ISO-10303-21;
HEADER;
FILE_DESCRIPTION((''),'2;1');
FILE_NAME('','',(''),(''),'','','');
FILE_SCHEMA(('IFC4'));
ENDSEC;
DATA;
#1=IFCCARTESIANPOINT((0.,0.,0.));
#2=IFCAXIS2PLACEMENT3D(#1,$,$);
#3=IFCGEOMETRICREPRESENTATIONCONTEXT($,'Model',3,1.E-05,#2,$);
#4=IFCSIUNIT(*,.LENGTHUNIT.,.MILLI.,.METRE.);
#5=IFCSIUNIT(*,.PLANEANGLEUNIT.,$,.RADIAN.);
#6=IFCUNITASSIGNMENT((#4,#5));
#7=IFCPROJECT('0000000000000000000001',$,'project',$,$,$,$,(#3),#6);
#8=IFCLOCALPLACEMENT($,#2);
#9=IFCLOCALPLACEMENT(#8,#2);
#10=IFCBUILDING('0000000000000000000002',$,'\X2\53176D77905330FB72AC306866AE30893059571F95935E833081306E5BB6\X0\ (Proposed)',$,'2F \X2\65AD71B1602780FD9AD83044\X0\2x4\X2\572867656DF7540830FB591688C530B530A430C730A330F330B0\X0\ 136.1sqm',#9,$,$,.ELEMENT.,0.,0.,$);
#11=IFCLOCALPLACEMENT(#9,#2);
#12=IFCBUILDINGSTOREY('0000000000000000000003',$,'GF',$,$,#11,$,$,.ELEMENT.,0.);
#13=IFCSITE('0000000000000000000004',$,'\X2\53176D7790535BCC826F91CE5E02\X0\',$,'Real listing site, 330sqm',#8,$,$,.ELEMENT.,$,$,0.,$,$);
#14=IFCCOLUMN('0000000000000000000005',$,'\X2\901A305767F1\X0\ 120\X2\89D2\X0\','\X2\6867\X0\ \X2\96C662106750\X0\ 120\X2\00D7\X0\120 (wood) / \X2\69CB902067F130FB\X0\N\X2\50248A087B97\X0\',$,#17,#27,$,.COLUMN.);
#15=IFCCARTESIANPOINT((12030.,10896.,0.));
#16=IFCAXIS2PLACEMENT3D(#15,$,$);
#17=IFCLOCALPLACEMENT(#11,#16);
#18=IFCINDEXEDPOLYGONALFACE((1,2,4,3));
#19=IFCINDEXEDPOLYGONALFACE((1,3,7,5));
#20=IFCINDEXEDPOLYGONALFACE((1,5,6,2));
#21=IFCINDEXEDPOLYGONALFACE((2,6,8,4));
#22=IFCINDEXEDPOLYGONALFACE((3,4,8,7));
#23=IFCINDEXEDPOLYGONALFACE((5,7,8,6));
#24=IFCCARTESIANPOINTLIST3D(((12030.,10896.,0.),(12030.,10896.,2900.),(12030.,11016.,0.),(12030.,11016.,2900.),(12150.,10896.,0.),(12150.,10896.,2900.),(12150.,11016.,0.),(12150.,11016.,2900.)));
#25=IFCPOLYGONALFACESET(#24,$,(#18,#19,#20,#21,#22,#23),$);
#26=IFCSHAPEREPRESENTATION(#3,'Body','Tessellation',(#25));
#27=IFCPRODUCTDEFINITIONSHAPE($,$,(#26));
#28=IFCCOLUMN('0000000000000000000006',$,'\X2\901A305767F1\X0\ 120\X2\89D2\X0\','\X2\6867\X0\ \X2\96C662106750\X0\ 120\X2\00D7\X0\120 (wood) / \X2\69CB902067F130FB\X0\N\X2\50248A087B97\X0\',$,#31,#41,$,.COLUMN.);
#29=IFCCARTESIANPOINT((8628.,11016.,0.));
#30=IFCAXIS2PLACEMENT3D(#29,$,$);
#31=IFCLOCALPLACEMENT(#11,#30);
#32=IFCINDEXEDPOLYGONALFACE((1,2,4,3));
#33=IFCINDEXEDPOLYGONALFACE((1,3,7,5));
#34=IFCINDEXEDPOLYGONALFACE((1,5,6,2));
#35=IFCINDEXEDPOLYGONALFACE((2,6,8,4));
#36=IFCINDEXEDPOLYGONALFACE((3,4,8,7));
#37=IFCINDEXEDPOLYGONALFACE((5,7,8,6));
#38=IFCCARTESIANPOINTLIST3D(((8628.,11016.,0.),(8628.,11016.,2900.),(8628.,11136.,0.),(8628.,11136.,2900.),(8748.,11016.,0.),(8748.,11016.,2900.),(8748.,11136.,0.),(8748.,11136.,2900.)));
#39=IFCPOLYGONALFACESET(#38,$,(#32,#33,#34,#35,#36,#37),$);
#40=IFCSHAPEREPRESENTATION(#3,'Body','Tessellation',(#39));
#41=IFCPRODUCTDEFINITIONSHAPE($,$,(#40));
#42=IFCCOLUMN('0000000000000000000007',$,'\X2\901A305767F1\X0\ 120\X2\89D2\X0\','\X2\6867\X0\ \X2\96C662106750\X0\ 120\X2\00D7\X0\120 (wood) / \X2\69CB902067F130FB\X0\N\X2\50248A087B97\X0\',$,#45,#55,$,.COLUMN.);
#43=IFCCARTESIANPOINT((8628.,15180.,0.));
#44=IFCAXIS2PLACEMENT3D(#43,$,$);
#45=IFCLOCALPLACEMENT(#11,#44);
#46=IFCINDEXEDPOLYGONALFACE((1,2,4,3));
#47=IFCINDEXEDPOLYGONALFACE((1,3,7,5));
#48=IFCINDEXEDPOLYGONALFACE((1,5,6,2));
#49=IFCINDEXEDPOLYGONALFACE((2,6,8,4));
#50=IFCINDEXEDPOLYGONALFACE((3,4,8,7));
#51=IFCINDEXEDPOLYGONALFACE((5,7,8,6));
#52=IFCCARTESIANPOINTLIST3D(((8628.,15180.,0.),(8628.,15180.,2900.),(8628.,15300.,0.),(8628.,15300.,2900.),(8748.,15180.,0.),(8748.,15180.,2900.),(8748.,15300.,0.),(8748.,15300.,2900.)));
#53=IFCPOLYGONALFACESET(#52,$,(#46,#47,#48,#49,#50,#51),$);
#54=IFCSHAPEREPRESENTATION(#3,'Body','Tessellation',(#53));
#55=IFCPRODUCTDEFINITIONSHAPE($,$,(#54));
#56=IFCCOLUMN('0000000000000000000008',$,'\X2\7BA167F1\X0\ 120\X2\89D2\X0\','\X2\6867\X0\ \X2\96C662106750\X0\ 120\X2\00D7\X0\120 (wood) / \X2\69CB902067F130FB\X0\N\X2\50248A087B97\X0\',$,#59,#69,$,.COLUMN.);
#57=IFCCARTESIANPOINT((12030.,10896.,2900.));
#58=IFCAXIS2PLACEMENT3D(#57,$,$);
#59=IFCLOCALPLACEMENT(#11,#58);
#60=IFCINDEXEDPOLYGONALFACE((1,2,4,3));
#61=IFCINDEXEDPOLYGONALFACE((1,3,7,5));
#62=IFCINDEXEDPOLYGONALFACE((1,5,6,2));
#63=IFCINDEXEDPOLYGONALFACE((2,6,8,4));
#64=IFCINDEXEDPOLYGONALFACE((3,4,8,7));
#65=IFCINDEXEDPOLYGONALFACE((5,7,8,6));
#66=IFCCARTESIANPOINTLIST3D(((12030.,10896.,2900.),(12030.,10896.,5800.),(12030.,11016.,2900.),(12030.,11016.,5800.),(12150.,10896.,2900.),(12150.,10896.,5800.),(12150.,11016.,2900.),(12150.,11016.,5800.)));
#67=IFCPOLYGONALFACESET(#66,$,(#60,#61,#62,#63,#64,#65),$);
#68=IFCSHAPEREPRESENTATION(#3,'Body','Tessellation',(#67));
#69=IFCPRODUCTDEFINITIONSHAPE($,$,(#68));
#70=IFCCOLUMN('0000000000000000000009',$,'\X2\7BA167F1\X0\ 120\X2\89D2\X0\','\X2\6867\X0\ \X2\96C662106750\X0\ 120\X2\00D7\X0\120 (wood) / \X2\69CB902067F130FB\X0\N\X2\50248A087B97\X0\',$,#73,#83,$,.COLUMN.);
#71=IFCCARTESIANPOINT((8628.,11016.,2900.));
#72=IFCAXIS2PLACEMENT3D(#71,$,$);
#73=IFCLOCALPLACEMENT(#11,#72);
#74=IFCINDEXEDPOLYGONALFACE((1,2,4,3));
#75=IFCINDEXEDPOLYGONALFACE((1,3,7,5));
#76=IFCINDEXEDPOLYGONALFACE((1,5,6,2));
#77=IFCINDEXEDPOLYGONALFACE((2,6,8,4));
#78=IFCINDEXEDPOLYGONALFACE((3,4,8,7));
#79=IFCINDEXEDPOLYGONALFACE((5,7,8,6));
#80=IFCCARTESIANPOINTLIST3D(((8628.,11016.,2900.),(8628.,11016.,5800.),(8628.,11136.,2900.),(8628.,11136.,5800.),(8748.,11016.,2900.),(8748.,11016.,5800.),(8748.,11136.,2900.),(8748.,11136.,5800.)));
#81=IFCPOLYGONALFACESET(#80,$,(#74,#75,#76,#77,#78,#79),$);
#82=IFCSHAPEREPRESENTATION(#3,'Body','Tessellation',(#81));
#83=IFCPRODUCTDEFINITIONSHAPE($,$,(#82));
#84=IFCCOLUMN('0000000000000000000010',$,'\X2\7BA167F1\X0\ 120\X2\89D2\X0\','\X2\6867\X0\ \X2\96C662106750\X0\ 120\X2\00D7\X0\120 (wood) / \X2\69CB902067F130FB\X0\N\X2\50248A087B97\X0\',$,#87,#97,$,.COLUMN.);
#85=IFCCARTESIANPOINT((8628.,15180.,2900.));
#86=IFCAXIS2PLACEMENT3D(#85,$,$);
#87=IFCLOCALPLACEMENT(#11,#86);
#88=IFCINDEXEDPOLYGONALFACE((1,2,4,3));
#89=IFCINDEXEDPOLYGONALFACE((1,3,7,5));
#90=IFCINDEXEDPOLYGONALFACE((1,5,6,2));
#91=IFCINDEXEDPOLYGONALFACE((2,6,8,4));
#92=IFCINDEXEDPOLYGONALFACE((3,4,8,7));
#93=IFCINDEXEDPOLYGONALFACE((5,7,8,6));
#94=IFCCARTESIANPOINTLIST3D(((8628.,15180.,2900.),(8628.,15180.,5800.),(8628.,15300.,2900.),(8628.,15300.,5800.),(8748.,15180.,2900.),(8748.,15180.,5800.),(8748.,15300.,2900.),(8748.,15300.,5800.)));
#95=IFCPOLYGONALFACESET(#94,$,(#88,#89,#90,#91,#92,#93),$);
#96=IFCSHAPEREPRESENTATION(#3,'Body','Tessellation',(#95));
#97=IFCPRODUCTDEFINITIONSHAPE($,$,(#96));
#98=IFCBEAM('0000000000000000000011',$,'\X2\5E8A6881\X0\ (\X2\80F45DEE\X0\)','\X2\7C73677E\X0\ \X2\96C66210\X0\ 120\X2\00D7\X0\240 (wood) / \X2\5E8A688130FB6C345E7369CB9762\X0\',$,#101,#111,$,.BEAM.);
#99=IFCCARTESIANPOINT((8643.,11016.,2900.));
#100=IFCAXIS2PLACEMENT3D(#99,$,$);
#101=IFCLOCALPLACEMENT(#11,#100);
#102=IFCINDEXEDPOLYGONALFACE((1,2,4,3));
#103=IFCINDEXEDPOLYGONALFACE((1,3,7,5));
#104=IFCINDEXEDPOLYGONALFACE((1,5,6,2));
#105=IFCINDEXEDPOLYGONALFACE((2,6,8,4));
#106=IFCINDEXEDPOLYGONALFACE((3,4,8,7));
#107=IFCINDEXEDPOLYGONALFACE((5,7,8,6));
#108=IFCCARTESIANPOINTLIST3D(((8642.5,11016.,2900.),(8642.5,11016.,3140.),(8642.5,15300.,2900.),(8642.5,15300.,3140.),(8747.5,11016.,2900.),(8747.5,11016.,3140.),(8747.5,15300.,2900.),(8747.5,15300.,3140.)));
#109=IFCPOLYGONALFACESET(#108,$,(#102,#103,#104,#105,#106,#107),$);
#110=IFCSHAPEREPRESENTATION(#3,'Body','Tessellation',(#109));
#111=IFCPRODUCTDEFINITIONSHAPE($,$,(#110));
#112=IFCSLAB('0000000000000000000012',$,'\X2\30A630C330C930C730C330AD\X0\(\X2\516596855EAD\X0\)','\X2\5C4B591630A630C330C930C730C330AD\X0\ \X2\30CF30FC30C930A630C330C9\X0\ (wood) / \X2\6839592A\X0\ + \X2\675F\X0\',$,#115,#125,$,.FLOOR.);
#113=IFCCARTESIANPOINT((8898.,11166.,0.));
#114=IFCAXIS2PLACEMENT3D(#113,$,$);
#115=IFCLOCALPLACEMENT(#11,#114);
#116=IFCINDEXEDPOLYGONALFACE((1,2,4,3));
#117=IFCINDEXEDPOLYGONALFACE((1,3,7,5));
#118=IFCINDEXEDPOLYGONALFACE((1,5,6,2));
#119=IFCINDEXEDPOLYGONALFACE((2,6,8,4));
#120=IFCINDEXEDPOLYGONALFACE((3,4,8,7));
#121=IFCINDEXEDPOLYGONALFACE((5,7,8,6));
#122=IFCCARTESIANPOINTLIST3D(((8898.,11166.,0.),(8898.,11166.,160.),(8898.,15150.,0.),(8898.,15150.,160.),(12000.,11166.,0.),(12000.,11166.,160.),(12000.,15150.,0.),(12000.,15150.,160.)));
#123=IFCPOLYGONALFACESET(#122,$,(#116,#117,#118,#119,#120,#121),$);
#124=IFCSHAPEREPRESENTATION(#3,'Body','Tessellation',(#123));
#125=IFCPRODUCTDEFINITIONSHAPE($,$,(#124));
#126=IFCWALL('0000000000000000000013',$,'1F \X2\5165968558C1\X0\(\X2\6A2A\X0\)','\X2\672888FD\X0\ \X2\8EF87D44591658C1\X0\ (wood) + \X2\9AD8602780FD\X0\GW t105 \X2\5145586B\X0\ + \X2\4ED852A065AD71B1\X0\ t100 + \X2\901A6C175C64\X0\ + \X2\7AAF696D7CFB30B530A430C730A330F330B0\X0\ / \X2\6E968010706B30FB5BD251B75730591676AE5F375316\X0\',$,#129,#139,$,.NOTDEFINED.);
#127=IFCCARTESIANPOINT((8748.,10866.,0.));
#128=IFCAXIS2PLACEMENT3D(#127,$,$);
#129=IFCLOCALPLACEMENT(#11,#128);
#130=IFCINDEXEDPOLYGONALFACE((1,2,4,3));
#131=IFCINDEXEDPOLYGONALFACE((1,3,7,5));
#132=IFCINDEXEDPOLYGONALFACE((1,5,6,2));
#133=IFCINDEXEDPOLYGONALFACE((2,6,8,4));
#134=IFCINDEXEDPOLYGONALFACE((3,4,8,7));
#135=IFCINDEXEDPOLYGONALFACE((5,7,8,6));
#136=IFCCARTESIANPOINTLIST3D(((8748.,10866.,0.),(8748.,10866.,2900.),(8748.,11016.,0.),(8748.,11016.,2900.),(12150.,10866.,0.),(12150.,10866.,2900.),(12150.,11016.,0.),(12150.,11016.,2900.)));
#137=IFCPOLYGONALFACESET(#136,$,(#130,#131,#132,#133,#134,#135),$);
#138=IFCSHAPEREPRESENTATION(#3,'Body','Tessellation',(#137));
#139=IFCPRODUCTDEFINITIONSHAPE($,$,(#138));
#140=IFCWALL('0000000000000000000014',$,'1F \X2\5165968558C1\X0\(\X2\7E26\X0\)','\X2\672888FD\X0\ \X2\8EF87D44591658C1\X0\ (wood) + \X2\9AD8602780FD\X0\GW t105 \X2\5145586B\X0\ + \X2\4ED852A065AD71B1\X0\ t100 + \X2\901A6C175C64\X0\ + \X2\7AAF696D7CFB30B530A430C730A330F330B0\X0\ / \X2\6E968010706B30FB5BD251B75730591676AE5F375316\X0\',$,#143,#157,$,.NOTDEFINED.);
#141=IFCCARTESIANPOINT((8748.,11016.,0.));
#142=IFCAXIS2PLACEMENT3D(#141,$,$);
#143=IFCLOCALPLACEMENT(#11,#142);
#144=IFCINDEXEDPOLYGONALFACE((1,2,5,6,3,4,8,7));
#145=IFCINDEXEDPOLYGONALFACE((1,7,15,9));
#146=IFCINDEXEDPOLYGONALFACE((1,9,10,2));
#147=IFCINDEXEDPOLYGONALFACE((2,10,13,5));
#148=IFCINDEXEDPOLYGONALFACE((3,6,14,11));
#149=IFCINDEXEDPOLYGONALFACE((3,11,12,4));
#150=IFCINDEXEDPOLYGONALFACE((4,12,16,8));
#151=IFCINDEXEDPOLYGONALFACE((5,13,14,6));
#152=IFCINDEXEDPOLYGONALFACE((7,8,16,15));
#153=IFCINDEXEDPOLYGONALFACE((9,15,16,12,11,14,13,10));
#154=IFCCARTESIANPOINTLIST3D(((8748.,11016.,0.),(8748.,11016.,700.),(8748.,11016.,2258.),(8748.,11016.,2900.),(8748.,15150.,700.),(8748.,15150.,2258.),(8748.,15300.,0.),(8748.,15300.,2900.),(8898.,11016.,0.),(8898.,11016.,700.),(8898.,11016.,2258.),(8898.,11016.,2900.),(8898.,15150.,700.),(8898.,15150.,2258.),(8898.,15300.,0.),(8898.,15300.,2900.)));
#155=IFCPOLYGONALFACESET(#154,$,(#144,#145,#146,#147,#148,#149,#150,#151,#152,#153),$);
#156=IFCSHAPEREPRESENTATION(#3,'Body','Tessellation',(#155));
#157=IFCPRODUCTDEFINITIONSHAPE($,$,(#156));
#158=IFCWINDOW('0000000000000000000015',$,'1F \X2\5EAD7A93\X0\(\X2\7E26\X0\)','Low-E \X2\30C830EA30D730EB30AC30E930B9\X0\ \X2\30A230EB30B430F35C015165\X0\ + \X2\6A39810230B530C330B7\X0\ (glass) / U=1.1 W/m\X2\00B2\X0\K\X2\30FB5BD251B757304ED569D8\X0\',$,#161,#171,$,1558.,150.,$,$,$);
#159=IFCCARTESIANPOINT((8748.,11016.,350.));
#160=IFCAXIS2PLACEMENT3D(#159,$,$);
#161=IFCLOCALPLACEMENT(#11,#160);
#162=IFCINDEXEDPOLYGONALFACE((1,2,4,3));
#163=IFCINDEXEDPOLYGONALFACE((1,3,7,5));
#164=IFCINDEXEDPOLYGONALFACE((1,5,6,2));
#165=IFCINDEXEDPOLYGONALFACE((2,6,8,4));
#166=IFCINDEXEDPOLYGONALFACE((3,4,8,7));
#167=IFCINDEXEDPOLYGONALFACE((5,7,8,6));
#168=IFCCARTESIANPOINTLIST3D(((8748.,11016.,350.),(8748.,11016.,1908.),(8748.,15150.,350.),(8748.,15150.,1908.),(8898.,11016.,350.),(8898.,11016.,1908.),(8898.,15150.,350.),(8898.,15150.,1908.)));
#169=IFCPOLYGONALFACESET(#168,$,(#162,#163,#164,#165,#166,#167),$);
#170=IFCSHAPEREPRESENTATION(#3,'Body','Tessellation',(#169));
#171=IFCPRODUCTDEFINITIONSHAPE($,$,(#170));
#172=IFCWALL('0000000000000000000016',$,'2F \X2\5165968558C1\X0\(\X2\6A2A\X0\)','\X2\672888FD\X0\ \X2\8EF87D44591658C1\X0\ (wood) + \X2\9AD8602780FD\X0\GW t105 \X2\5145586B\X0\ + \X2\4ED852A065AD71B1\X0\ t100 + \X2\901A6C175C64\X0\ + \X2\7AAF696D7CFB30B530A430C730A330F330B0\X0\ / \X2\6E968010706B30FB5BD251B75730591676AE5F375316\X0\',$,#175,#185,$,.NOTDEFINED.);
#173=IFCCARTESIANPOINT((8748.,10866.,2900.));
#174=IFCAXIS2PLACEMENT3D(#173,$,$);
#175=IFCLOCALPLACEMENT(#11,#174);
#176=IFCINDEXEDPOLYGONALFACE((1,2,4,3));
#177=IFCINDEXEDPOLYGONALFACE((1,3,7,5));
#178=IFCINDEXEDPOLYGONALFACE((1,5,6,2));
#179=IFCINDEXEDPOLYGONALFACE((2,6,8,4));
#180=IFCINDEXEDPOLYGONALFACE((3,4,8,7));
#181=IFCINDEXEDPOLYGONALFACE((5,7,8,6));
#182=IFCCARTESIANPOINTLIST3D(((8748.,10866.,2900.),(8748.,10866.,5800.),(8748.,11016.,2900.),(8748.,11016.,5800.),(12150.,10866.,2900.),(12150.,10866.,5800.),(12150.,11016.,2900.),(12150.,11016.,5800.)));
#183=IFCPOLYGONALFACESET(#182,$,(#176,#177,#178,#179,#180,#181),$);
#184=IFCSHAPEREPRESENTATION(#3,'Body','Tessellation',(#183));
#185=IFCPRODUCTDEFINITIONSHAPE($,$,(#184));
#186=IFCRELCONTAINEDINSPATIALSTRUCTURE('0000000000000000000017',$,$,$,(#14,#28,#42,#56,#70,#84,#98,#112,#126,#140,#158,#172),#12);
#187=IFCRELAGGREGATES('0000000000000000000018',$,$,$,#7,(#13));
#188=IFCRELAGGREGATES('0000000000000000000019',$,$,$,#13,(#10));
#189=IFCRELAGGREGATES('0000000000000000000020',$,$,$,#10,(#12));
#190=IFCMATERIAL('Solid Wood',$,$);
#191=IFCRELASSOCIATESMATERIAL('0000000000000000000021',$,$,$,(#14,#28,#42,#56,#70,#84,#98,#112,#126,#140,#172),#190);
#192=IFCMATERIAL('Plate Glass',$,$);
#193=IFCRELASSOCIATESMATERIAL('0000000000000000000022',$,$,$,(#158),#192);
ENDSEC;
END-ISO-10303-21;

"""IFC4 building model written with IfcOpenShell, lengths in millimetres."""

from ifc_helpers import new_model, si_unit, frame, frame_2d, origin, place, context, project, spatial, rectangle, extrude, material, element, fill, save


model = new_model("IFC4")

# Units and contexts
model_context = context("Model", 3, precision=1e-05, world=origin())
ifc_project = project(units=[si_unit("LENGTHUNIT", "METRE", prefix="MILLI"), si_unit("PLANEANGLEUNIT", "RADIAN")], contexts=[model_context])

# Site, building, storey
site_placement = place(None, origin())
site = spatial("IfcSite", under=ifc_project, at=site_placement, Name="北海道富良野市", ObjectType="Real listing site, 330sqm", CompositionType="ELEMENT", RefElevation=0.0)
building_placement = place(site_placement, origin())
building = spatial("IfcBuilding", under=site, at=building_placement, Name="北海道・犬と暮らす土間広めの家 (Proposed)", ObjectType="2F 断熱性能高い2x4在来混合・外装サイディング 136.1sqm", CompositionType="ELEMENT", ElevationOfRefHeight=0.0, ElevationOfTerrain=0.0)
storey_placement = place(building_placement, origin())
storey = spatial("IfcBuildingStorey", under=building, at=storey_placement, Name="GF", CompositionType="ELEMENT", Elevation=0.0)

# Columns
ifc_material_1 = material(Name="Solid Wood")
column_1_placement = place(storey_placement, frame((12030.0, 10896.0, 0.0)))
element("IfcColumn", 1, at=column_1_placement, inside=storey, material=ifc_material_1, Name="通し柱 120角", Description="桧 集成材 120×120 (wood) / 構造柱・N値計算", PredefinedType="COLUMN", context=model_context, shape_type="SweptSolid", body=[
    extrude(rectangle(XDim=120.0, YDim=120.0, at=frame_2d((60.0, 60.0))), frame((12030.0, 10896.0, 0.0)), (0.0, 0.0, 1.0), 2900.0),
])
column_2_placement = place(storey_placement, frame((8628.0, 11016.0, 0.0)))
element("IfcColumn", 2, at=column_2_placement, inside=storey, material=ifc_material_1, Name="通し柱 120角", Description="桧 集成材 120×120 (wood) / 構造柱・N値計算", PredefinedType="COLUMN", context=model_context, shape_type="SweptSolid", body=[
    extrude(rectangle(XDim=120.0, YDim=120.0, at=frame_2d((60.0, 60.0))), frame((8628.0, 11016.0, 0.0)), (0.0, 0.0, 1.0), 2900.0),
])
column_3_placement = place(storey_placement, frame((8628.0, 15180.0, 0.0)))
element("IfcColumn", 3, at=column_3_placement, inside=storey, material=ifc_material_1, Name="通し柱 120角", Description="桧 集成材 120×120 (wood) / 構造柱・N値計算", PredefinedType="COLUMN", context=model_context, shape_type="SweptSolid", body=[
    extrude(rectangle(XDim=120.0, YDim=120.0, at=frame_2d((60.0, 60.0))), frame((8628.0, 15180.0, 0.0)), (0.0, 0.0, 1.0), 2900.0),
])
column_4_placement = place(storey_placement, frame((12030.0, 10896.0, 2900.0)))
element("IfcColumn", 4, at=column_4_placement, inside=storey, material=ifc_material_1, Name="管柱 120角", Description="桧 集成材 120×120 (wood) / 構造柱・N値計算", PredefinedType="COLUMN", context=model_context, shape_type="SweptSolid", body=[
    extrude(rectangle(XDim=120.0, YDim=120.0, at=frame_2d((60.0, 60.0))), frame((12030.0, 10896.0, 2900.0)), (0.0, 0.0, 1.0), 2900.0),
])
column_5_placement = place(storey_placement, frame((8628.0, 11016.0, 2900.0)))
element("IfcColumn", 5, at=column_5_placement, inside=storey, material=ifc_material_1, Name="管柱 120角", Description="桧 集成材 120×120 (wood) / 構造柱・N値計算", PredefinedType="COLUMN", context=model_context, shape_type="SweptSolid", body=[
    extrude(rectangle(XDim=120.0, YDim=120.0, at=frame_2d((60.0, 60.0))), frame((8628.0, 11016.0, 2900.0)), (0.0, 0.0, 1.0), 2900.0),
])
column_6_placement = place(storey_placement, frame((8628.0, 15180.0, 2900.0)))
element("IfcColumn", 6, at=column_6_placement, inside=storey, material=ifc_material_1, Name="管柱 120角", Description="桧 集成材 120×120 (wood) / 構造柱・N値計算", PredefinedType="COLUMN", context=model_context, shape_type="SweptSolid", body=[
    extrude(rectangle(XDim=120.0, YDim=120.0, at=frame_2d((60.0, 60.0))), frame((8628.0, 15180.0, 2900.0)), (0.0, 0.0, 1.0), 2900.0),
])

# Beam
beam_1_placement = place(storey_placement, frame((8643.0, 11016.0, 2900.0)))
element("IfcBeam", 7, at=beam_1_placement, inside=storey, material=ifc_material_1, Name="床梁 (胴差)", Description="米松 集成 120×240 (wood) / 床梁・水平構面", PredefinedType="BEAM", context=model_context, shape_type="SweptSolid", body=[
    extrude(rectangle(XDim=105.0, YDim=4284.0, at=frame_2d((52.0, 2142.0))), frame((8643.0, 11016.0, 2900.0)), (0.0, 0.0, 1.0), 240.0),
])

# Slab
slab_placement = place(storey_placement, frame((8898.0, 11166.0, 0.0)))
element("IfcSlab", 8, at=slab_placement, inside=storey, material=ifc_material_1, Name="ウッドデッキ(入隅庭)", Description="屋外ウッドデッキ ハードウッド (wood) / 根太 + 束", PredefinedType="FLOOR", context=model_context, shape_type="SweptSolid", body=[
    extrude(rectangle(XDim=3102.0, YDim=3984.0, at=frame_2d((1551.0, 1992.0))), frame((8898.0, 11166.0, 0.0)), (0.0, 0.0, 1.0), 160.0),
])

# Wall
wall_1_placement = place(storey_placement, frame((8748.0, 10866.0, 0.0)))
element("IfcWall", 9, at=wall_1_placement, inside=storey, material=ifc_material_1, Name="1F 入隅壁(横)", Description="木製 軸組外壁 (wood) + 高性能GW t105 充填 + 付加断熱 t100 + 通気層 + 窯業系サイディング / 準耐火・寒冷地外皮強化", PredefinedType="NOTDEFINED", context=model_context, shape_type="SweptSolid", body=[
    extrude(rectangle(XDim=3402.0, YDim=150.0, at=frame_2d((1701.0, 75.0))), frame((8748.0, 10866.0, 0.0)), (0.0, 0.0, 1.0), 2900.0),
])

# Wall, opening, window
wall_2_placement = place(storey_placement, frame((8748.0, 11016.0, 0.0)))
wall_2 = element("IfcWall", 10, at=wall_2_placement, inside=storey, material=ifc_material_1, Name="1F 入隅壁(縦)", Description="木製 軸組外壁 (wood) + 高性能GW t105 充填 + 付加断熱 t100 + 通気層 + 窯業系サイディング / 準耐火・寒冷地外皮強化", PredefinedType="NOTDEFINED", context=model_context, shape_type="SweptSolid", body=[
    extrude(rectangle(XDim=150.0, YDim=4284.0, at=frame_2d((75.0, 2142.0))), frame((8748.0, 11016.0, 0.0)), (0.0, 0.0, 1.0), 2900.0),
])
opening_1_placement = place(storey_placement, frame((8748.0, 11016.0, 350.0)))
opening_1 = element("IfcOpeningElement", 11, at=opening_1_placement, cuts=wall_2, PredefinedType="NOTDEFINED", context=model_context, shape_type="SweptSolid", body=[
    extrude(rectangle(XDim=150.0, YDim=4134.0, at=frame_2d((75.0, 2067.0))), frame((8748.0, 11016.0, 350.0)), (0.0, 0.0, 1.0), 1558.0),
])
ifc_material_2 = material(Name="Plate Glass")
window_1_placement = place(storey_placement, frame((8748.0, 11016.0, 350.0)))
window_1 = element("IfcWindow", 12, at=window_1_placement, inside=storey, material=ifc_material_2, Name="1F 庭窓(縦)", Description="Low-E トリプルガラス アルゴン封入 + 樹脂サッシ (glass) / U=1.1 W/m²K・寒冷地仕様", OverallHeight=1558.0, OverallWidth=150.0, context=model_context, shape_type="SweptSolid", body=[
    extrude(rectangle(XDim=150.0, YDim=4134.0, at=frame_2d((75.0, 2067.0))), frame((8748.0, 11016.0, 350.0)), (0.0, 0.0, 1.0), 1558.0),
])
fill(opening_1, window_1)

# Wall
wall_3_placement = place(storey_placement, frame((8748.0, 10866.0, 2900.0)))
element("IfcWall", 13, at=wall_3_placement, inside=storey, material=ifc_material_1, Name="2F 入隅壁(横)", Description="木製 軸組外壁 (wood) + 高性能GW t105 充填 + 付加断熱 t100 + 通気層 + 窯業系サイディング / 準耐火・寒冷地外皮強化", PredefinedType="NOTDEFINED", context=model_context, shape_type="SweptSolid", body=[
    extrude(rectangle(XDim=3402.0, YDim=150.0, at=frame_2d((1701.0, 75.0))), frame((8748.0, 10866.0, 2900.0)), (0.0, 0.0, 1.0), 2900.0),
])

save(model, "model.ifc")
